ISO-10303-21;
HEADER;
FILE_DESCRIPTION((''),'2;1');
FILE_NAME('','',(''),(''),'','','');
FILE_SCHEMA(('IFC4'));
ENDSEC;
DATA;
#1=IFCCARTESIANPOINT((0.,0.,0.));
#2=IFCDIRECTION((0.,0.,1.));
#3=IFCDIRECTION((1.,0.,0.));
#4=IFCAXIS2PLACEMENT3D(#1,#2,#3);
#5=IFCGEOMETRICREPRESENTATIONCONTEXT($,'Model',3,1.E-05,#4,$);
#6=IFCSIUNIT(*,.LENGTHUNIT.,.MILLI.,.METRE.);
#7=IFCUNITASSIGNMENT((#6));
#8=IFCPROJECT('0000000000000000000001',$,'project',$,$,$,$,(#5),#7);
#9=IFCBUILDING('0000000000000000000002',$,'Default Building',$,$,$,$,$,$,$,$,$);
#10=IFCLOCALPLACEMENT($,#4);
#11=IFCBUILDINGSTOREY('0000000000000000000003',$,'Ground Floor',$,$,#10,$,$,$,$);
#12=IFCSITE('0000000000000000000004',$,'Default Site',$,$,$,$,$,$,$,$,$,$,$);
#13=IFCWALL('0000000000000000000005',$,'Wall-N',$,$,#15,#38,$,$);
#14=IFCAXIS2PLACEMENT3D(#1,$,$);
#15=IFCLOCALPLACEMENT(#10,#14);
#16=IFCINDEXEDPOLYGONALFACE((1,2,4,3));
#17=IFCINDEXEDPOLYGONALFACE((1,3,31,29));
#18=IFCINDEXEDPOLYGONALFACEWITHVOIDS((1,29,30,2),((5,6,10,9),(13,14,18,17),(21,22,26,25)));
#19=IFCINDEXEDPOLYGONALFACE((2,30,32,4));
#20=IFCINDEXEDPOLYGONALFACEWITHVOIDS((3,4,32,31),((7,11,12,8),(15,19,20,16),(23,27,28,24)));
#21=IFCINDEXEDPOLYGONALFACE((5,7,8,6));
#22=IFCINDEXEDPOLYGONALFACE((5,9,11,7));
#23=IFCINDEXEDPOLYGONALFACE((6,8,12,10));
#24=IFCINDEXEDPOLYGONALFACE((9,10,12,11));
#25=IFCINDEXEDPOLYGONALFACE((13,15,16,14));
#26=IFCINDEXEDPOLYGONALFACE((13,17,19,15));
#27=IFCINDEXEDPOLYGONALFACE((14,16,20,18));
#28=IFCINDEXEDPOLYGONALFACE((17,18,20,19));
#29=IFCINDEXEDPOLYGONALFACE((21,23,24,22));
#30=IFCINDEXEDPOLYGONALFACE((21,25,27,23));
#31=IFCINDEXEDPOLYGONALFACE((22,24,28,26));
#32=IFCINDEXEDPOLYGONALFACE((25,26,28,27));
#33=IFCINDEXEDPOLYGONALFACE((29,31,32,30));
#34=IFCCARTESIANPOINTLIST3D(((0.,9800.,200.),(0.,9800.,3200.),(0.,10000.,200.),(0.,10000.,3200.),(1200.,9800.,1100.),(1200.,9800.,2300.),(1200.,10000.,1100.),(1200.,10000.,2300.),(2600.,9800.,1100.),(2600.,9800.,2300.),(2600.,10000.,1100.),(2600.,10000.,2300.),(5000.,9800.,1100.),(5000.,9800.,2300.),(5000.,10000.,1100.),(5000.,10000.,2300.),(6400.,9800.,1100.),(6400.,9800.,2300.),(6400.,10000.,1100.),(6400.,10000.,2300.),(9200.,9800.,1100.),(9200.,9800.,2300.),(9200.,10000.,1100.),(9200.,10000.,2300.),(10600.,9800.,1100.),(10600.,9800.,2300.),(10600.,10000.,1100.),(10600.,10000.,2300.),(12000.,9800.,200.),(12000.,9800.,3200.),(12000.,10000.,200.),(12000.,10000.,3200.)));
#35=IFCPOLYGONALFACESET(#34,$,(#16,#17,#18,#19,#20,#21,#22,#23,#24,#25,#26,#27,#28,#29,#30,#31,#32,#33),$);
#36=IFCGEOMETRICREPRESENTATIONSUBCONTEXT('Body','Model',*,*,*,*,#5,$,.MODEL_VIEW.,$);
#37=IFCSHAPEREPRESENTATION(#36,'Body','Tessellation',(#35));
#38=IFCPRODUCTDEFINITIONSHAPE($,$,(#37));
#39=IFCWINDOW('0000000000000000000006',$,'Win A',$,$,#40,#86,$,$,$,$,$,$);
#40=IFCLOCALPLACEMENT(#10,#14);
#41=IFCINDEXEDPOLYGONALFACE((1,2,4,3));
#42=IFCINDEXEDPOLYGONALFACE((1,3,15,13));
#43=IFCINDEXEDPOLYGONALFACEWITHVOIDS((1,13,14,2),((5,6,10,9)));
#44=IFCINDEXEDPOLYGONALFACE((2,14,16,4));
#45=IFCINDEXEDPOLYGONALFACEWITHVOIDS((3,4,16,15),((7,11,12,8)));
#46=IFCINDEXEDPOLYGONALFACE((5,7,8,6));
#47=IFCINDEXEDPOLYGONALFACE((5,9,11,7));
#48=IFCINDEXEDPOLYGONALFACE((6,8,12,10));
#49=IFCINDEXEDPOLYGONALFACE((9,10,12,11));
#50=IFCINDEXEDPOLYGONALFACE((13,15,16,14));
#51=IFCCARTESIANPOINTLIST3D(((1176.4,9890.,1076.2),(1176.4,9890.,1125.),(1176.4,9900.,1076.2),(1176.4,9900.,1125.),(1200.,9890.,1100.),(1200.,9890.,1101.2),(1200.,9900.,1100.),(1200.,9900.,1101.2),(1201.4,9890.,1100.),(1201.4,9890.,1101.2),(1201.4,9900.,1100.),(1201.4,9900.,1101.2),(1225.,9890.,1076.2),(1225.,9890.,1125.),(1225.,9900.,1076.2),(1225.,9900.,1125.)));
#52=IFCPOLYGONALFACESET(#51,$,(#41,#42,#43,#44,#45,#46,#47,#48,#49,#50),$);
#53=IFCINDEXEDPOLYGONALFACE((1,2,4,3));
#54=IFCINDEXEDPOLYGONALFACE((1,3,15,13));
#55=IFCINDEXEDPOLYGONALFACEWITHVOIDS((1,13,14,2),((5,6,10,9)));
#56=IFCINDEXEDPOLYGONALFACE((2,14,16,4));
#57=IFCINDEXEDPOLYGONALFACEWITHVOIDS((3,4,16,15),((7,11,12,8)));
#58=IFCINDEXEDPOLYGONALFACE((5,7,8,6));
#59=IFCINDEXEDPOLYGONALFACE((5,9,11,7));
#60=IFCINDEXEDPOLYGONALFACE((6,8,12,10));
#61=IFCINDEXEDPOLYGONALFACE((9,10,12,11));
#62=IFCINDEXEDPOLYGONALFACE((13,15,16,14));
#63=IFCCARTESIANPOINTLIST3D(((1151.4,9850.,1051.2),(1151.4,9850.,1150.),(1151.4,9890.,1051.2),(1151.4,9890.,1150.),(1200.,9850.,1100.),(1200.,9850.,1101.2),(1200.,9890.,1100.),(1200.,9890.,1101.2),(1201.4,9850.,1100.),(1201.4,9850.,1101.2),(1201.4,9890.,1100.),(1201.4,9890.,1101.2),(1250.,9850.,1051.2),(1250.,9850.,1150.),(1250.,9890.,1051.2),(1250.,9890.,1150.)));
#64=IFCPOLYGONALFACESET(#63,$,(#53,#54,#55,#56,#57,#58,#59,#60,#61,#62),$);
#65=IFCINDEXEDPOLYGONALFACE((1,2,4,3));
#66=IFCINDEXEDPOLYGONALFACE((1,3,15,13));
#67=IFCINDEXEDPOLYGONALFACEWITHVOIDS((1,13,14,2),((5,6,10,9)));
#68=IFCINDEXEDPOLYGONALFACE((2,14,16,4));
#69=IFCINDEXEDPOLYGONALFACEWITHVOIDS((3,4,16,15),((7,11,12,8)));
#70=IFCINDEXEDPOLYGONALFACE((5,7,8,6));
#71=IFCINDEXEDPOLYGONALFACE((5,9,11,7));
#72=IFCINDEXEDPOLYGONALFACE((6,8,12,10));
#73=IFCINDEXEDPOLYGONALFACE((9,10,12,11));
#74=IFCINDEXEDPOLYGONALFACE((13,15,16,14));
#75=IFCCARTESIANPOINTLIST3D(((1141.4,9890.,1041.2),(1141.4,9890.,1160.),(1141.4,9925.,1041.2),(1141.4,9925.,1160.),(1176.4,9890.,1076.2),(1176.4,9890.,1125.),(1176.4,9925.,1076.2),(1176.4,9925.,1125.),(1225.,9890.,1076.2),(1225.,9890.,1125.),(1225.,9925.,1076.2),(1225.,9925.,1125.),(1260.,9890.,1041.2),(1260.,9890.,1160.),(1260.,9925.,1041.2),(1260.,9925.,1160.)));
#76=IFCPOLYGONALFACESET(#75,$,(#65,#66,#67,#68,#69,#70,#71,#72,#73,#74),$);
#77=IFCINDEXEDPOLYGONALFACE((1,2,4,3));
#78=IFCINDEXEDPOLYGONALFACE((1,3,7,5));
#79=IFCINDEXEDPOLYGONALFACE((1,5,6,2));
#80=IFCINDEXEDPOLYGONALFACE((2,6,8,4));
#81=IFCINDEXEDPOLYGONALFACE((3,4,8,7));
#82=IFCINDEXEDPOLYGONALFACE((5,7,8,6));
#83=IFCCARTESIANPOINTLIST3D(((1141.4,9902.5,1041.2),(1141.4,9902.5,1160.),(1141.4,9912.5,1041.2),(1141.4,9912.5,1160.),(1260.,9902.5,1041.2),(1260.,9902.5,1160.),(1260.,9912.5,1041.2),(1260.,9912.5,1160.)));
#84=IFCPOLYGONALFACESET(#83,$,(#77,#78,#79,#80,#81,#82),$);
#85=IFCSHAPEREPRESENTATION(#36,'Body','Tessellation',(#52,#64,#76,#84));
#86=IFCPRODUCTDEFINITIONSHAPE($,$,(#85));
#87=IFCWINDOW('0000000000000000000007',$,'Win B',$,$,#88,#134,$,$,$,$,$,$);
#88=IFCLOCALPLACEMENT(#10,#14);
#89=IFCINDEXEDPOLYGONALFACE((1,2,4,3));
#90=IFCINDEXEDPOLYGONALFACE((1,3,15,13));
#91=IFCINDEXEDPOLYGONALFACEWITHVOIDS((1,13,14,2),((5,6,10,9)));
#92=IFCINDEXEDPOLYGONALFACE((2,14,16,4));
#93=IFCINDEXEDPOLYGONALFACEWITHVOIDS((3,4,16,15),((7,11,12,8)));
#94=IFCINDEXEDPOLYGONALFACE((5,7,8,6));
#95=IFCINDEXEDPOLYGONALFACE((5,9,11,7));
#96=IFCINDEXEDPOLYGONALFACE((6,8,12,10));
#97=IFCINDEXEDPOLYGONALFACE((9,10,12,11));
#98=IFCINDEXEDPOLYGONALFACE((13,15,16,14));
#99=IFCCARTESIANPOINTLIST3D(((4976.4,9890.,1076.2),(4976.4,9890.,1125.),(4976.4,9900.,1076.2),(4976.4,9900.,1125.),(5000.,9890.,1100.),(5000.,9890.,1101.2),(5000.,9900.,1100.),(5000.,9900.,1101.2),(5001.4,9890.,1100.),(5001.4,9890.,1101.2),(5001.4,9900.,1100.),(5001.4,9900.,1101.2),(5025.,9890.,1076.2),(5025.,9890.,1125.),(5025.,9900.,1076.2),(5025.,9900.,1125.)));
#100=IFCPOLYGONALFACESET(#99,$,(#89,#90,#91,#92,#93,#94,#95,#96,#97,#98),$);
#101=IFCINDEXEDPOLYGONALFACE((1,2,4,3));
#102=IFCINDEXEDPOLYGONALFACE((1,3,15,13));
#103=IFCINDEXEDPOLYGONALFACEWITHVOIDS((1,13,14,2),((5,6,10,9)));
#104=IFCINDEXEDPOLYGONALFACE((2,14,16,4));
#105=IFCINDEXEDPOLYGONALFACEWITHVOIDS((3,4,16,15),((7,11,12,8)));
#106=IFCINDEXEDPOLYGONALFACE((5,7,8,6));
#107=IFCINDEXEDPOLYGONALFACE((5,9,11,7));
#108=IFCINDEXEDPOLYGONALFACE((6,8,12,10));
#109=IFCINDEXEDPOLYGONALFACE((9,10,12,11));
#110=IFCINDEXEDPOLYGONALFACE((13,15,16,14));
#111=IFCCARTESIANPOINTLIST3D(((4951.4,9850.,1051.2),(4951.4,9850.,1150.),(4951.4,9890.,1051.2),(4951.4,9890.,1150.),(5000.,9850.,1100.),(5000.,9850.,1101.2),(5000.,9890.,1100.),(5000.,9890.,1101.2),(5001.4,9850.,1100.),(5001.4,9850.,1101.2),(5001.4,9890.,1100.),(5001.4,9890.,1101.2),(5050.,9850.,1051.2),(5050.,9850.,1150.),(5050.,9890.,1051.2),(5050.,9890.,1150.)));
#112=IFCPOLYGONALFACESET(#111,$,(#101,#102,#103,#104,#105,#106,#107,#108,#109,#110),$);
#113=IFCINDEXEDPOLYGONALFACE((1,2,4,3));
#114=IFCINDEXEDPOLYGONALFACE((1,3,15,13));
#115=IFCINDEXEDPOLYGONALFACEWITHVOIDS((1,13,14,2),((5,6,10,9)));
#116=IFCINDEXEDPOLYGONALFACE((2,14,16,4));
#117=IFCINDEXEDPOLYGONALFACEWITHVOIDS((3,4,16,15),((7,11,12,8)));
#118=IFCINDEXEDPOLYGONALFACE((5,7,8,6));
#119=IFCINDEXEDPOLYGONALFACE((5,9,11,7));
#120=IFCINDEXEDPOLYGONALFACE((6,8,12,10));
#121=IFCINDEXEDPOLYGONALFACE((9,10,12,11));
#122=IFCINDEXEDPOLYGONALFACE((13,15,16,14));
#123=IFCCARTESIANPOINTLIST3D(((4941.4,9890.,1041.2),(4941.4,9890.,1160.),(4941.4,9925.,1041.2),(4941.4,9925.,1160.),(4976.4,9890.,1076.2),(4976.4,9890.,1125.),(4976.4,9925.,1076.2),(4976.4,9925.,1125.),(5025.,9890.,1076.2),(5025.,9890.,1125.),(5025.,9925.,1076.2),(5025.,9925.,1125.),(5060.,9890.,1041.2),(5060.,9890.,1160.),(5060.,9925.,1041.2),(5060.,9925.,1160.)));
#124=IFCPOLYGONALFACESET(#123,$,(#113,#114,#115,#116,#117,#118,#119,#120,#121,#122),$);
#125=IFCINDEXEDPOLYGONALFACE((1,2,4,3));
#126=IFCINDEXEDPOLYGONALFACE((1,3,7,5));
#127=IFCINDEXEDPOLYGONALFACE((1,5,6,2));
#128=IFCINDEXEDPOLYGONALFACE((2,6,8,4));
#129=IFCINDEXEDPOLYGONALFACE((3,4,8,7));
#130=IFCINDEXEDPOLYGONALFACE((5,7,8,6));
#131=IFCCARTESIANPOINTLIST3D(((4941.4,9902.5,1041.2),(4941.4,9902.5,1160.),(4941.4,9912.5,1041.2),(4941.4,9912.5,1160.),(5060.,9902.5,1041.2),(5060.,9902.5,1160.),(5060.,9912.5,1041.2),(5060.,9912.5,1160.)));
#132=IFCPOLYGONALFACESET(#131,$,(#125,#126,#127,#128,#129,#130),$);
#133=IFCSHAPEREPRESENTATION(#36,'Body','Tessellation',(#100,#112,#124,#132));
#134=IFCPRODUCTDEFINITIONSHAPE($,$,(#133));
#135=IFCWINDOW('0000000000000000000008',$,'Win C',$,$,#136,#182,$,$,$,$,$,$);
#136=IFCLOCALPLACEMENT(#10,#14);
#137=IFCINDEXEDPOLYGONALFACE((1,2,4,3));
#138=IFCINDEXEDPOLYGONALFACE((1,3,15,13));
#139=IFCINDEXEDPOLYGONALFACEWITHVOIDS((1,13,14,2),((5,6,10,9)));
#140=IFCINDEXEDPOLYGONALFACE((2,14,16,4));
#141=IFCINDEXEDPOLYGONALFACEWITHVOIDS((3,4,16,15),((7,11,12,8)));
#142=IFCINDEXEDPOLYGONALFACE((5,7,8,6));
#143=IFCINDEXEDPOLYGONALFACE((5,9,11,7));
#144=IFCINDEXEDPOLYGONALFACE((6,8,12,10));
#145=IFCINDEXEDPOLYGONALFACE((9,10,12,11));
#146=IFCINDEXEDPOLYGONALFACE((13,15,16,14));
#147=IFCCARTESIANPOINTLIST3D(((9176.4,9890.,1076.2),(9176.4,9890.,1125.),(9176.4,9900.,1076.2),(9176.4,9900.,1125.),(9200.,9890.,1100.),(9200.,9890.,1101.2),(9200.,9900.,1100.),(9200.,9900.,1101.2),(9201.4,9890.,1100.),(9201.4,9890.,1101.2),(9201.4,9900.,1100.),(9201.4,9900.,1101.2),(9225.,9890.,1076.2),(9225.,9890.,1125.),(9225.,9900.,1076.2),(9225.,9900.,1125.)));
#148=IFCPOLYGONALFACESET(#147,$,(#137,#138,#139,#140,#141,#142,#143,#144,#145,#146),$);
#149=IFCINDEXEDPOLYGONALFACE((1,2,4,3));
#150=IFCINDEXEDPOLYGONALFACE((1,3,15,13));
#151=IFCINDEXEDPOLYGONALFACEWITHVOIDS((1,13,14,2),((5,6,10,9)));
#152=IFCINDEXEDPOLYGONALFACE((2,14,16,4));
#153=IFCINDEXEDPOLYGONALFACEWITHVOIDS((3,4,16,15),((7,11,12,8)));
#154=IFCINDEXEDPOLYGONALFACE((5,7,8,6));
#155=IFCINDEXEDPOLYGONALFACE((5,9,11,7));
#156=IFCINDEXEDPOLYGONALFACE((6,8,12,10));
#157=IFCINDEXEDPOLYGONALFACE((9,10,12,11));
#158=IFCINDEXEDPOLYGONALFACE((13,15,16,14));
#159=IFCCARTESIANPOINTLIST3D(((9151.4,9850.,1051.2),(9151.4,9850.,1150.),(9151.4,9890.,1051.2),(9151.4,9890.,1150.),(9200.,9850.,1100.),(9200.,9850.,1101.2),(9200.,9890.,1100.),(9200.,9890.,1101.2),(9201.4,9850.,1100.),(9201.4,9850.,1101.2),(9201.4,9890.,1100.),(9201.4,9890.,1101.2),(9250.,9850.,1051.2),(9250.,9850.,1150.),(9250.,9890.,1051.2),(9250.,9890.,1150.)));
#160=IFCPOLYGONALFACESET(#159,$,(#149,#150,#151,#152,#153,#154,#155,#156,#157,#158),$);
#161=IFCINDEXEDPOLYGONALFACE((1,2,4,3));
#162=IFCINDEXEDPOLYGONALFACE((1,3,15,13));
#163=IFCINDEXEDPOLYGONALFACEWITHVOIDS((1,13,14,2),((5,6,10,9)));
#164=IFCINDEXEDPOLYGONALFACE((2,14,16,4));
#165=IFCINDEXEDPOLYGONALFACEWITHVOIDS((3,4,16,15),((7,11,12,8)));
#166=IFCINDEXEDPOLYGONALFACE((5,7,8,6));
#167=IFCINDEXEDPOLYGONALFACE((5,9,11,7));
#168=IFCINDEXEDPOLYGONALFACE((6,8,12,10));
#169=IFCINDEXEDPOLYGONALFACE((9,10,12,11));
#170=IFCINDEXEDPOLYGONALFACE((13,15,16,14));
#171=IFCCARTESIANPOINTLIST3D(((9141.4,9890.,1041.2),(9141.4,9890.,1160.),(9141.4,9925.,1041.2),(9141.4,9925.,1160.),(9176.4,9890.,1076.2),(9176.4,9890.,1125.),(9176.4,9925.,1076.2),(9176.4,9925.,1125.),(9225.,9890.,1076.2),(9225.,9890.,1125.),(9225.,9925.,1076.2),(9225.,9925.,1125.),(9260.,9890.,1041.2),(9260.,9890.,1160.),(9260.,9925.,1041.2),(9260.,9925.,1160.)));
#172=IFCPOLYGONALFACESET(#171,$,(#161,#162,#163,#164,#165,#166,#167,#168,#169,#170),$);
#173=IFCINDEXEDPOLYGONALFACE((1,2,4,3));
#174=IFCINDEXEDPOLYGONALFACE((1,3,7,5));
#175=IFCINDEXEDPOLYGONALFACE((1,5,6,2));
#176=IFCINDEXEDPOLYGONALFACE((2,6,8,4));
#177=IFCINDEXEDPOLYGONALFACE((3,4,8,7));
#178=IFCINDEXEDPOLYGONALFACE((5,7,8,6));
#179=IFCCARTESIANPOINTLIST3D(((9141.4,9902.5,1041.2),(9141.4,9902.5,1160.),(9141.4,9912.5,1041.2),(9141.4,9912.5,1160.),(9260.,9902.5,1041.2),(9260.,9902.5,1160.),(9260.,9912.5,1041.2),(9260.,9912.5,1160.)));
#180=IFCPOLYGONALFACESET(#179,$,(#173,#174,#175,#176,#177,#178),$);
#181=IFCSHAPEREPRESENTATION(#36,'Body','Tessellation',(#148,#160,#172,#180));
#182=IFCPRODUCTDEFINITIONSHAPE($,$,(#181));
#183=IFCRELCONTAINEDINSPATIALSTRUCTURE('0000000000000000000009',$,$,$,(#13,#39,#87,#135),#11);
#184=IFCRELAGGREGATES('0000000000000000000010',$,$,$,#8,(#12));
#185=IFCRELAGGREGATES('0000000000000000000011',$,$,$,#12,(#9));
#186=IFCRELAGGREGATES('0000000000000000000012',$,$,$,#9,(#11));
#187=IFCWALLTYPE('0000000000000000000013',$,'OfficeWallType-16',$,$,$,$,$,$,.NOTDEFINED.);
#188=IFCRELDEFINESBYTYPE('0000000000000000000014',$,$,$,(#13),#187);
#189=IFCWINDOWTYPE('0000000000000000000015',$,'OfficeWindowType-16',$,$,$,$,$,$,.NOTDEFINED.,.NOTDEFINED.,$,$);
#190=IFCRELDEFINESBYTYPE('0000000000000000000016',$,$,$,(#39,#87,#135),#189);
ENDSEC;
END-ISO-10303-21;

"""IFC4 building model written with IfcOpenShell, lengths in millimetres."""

from ifc_helpers import new_model, si_unit, frame, origin_with_axes, place, context, subcontext, project, spatial, line, indexed_curve, outline, extrude, type_object, element, fill, save


model = new_model("IFC4")

# Units and contexts
model_context = context("Model", 3, precision=1e-05, world=origin_with_axes())
body_context = subcontext(model_context, "Body", "Model", "MODEL_VIEW")
ifc_project = project(units=[si_unit("LENGTHUNIT", "METRE", prefix="MILLI")], contexts=[model_context])

# Site, building, storey
site = spatial("IfcSite", under=ifc_project, Name="Default Site")
building = spatial("IfcBuilding", under=site, Name="Default Building")
storey_placement = place(None, origin_with_axes())
storey = spatial("IfcBuildingStorey", under=building, at=storey_placement, Name="Ground Floor")

# Shared definitions
wall_type = type_object("IfcWallType", Name="OfficeWallType-16", PredefinedType="NOTDEFINED")

# Wall, openings, windows
wall_1_placement = place(storey_placement, frame((0.0, 0.0, 200.0), z_axis=(0.0, 0.0, 1.0), x_axis=(1.0, 0.0, 0.0)))
wall_1 = element("IfcWall", 1, at=wall_1_placement, inside=storey, type_object=wall_type, Name="Wall-N", context=body_context, shape_type="SweptSolid", body=[
    extrude(outline(indexed_curve([(0.0, 9800.0), (12000.0, 9800.0), (12000.0, 10000.0), (0.0, 10000.0), (0.0, 9800.0)])), None, (0.0, 0.0, 1.0), 3000.0),
])
opening_1_placement = place(wall_1_placement, frame((0.0, 0.0, 900.0), z_axis=(0.0, 0.0, 1.0), x_axis=(1.0, 0.0, 0.0)))
opening_1 = element("IfcOpeningElement", 2, at=opening_1_placement, cuts=wall_1, context=body_context, shape_type="SweptSolid", body=[
    extrude(outline(indexed_curve([(1200.0, 9800.0), (2600.0, 9800.0), (2600.0, 10000.0), (1200.0, 10000.0), (1200.0, 9800.0)])), None, (0.0, 0.0, 1.0), 1200.0),
])
opening_2_placement = place(wall_1_placement, frame((0.0, 0.0, 900.0), z_axis=(0.0, 0.0, 1.0), x_axis=(1.0, 0.0, 0.0)))
opening_2 = element("IfcOpeningElement", 3, at=opening_2_placement, cuts=wall_1, context=body_context, shape_type="SweptSolid", body=[
    extrude(outline(indexed_curve([(5000.0, 9800.0), (6400.0, 9800.0), (6400.0, 10000.0), (5000.0, 10000.0), (5000.0, 9800.0)])), None, (0.0, 0.0, 1.0), 1200.0),
])
opening_3_placement = place(wall_1_placement, frame((0.0, 0.0, 900.0), z_axis=(0.0, 0.0, 1.0), x_axis=(1.0, 0.0, 0.0)))
opening_3 = element("IfcOpeningElement", 4, at=opening_3_placement, cuts=wall_1, context=body_context, shape_type="SweptSolid", body=[
    extrude(outline(indexed_curve([(9200.0, 9800.0), (10600.0, 9800.0), (10600.0, 10000.0), (9200.0, 10000.0), (9200.0, 9800.0)])), None, (0.0, 0.0, 1.0), 1200.0),
])
window_type = type_object("IfcWindowType", Name="OfficeWindowType-16", PartitioningType="NOTDEFINED", PredefinedType="NOTDEFINED")
window_1_placement = place(storey_placement, frame((1200.0, 9800.0, 1100.0), z_axis=(0.0, 0.0, 1.0), x_axis=(1.0, 0.0, 0.0)))
window_1 = element("IfcWindow", 5, at=window_1_placement, inside=storey, type_object=window_type, Name="Win A", context=body_context, shape_type="SweptSolid", body=[
    extrude(outline(indexed_curve([(0.0, 0.0), (1.4, 0.0), (1.4, 1.2), (0.0, 1.2)], segments=[line(1, 2, 3, 4, 1)]), holes=[indexed_curve([(25.0, 25.0), (-23.6, 25.0), (-23.6, -23.8), (25.0, -23.8)], segments=[line(1, 2, 3, 4, 1)])]), frame((0.0, 90.0, 0.0), z_axis=(0.0, -1.0, 0.0), x_axis=(1.0, 0.0, 0.0)), (0.0, 0.0, -1.0), 10.0),
    extrude(outline(indexed_curve([(0.0, 0.0), (1.4, 0.0), (1.4, 1.2), (0.0, 1.2)], segments=[line(1, 2, 3, 4, 1)]), holes=[indexed_curve([(50.0, 50.0), (-48.6, 50.0), (-48.6, -48.8), (50.0, -48.8)], segments=[line(1, 2, 3, 4, 1)])]), frame((0.0, 50.0, 0.0), z_axis=(0.0, -1.0, 0.0), x_axis=(1.0, 0.0, 0.0)), (0.0, 0.0, -1.0), 40.0),
    extrude(outline(indexed_curve([(0.0, 0.0), (-48.6, 0.0), (-48.6, -48.8), (0.0, -48.8)], segments=[line(1, 2, 3, 4, 1)]), holes=[indexed_curve([(35.0, 35.0), (-83.6, 35.0), (-83.6, -83.8), (35.0, -83.8)], segments=[line(1, 2, 3, 4, 1)])]), frame((25.0, 90.0, 25.0), z_axis=(0.0, -1.0, 0.0), x_axis=(1.0, 0.0, 0.0)), (0.0, 0.0, -1.0), 35.0),
    extrude(outline(indexed_curve([(35.0, 35.0), (-83.6, 35.0), (-83.6, -83.8), (35.0, -83.8)], segments=[line(1, 2, 3, 4, 1)])), frame((25.0, 102.5, 25.0), z_axis=(0.0, -1.0, 0.0), x_axis=(1.0, 0.0, 0.0)), (0.0, 0.0, -1.0), 10.0),
])
fill(opening_1, window_1)
window_2_placement = place(storey_placement, frame((5000.0, 9800.0, 1100.0), z_axis=(0.0, 0.0, 1.0), x_axis=(1.0, 0.0, 0.0)))
window_2 = element("IfcWindow", 6, at=window_2_placement, inside=storey, type_object=window_type, Name="Win B", context=body_context, shape_type="SweptSolid", body=[
    extrude(outline(indexed_curve([(0.0, 0.0), (1.4, 0.0), (1.4, 1.2), (0.0, 1.2)], segments=[line(1, 2, 3, 4, 1)]), holes=[indexed_curve([(25.0, 25.0), (-23.6, 25.0), (-23.6, -23.8), (25.0, -23.8)], segments=[line(1, 2, 3, 4, 1)])]), frame((0.0, 90.0, 0.0), z_axis=(0.0, -1.0, 0.0), x_axis=(1.0, 0.0, 0.0)), (0.0, 0.0, -1.0), 10.0),
    extrude(outline(indexed_curve([(0.0, 0.0), (1.4, 0.0), (1.4, 1.2), (0.0, 1.2)], segments=[line(1, 2, 3, 4, 1)]), holes=[indexed_curve([(50.0, 50.0), (-48.6, 50.0), (-48.6, -48.8), (50.0, -48.8)], segments=[line(1, 2, 3, 4, 1)])]), frame((0.0, 50.0, 0.0), z_axis=(0.0, -1.0, 0.0), x_axis=(1.0, 0.0, 0.0)), (0.0, 0.0, -1.0), 40.0),
    extrude(outline(indexed_curve([(0.0, 0.0), (-48.6, 0.0), (-48.6, -48.8), (0.0, -48.8)], segments=[line(1, 2, 3, 4, 1)]), holes=[indexed_curve([(35.0, 35.0), (-83.6, 35.0), (-83.6, -83.8), (35.0, -83.8)], segments=[line(1, 2, 3, 4, 1)])]), frame((25.0, 90.0, 25.0), z_axis=(0.0, -1.0, 0.0), x_axis=(1.0, 0.0, 0.0)), (0.0, 0.0, -1.0), 35.0),
    extrude(outline(indexed_curve([(35.0, 35.0), (-83.6, 35.0), (-83.6, -83.8), (35.0, -83.8)], segments=[line(1, 2, 3, 4, 1)])), frame((25.0, 102.5, 25.0), z_axis=(0.0, -1.0, 0.0), x_axis=(1.0, 0.0, 0.0)), (0.0, 0.0, -1.0), 10.0),
])
fill(opening_2, window_2)
window_3_placement = place(storey_placement, frame((9200.0, 9800.0, 1100.0), z_axis=(0.0, 0.0, 1.0), x_axis=(1.0, 0.0, 0.0)))
window_3 = element("IfcWindow", 7, at=window_3_placement, inside=storey, type_object=window_type, Name="Win C", context=body_context, shape_type="SweptSolid", body=[
    extrude(outline(indexed_curve([(0.0, 0.0), (1.4, 0.0), (1.4, 1.2), (0.0, 1.2)], segments=[line(1, 2, 3, 4, 1)]), holes=[indexed_curve([(25.0, 25.0), (-23.6, 25.0), (-23.6, -23.8), (25.0, -23.8)], segments=[line(1, 2, 3, 4, 1)])]), frame((0.0, 90.0, 0.0), z_axis=(0.0, -1.0, 0.0), x_axis=(1.0, 0.0, 0.0)), (0.0, 0.0, -1.0), 10.0),
    extrude(outline(indexed_curve([(0.0, 0.0), (1.4, 0.0), (1.4, 1.2), (0.0, 1.2)], segments=[line(1, 2, 3, 4, 1)]), holes=[indexed_curve([(50.0, 50.0), (-48.6, 50.0), (-48.6, -48.8), (50.0, -48.8)], segments=[line(1, 2, 3, 4, 1)])]), frame((0.0, 50.0, 0.0), z_axis=(0.0, -1.0, 0.0), x_axis=(1.0, 0.0, 0.0)), (0.0, 0.0, -1.0), 40.0),
    extrude(outline(indexed_curve([(0.0, 0.0), (-48.6, 0.0), (-48.6, -48.8), (0.0, -48.8)], segments=[line(1, 2, 3, 4, 1)]), holes=[indexed_curve([(35.0, 35.0), (-83.6, 35.0), (-83.6, -83.8), (35.0, -83.8)], segments=[line(1, 2, 3, 4, 1)])]), frame((25.0, 90.0, 25.0), z_axis=(0.0, -1.0, 0.0), x_axis=(1.0, 0.0, 0.0)), (0.0, 0.0, -1.0), 35.0),
    extrude(outline(indexed_curve([(35.0, 35.0), (-83.6, 35.0), (-83.6, -83.8), (35.0, -83.8)], segments=[line(1, 2, 3, 4, 1)])), frame((25.0, 102.5, 25.0), z_axis=(0.0, -1.0, 0.0), x_axis=(1.0, 0.0, 0.0)), (0.0, 0.0, -1.0), 10.0),
])
fill(opening_3, window_3)

save(model, "model.ifc")
